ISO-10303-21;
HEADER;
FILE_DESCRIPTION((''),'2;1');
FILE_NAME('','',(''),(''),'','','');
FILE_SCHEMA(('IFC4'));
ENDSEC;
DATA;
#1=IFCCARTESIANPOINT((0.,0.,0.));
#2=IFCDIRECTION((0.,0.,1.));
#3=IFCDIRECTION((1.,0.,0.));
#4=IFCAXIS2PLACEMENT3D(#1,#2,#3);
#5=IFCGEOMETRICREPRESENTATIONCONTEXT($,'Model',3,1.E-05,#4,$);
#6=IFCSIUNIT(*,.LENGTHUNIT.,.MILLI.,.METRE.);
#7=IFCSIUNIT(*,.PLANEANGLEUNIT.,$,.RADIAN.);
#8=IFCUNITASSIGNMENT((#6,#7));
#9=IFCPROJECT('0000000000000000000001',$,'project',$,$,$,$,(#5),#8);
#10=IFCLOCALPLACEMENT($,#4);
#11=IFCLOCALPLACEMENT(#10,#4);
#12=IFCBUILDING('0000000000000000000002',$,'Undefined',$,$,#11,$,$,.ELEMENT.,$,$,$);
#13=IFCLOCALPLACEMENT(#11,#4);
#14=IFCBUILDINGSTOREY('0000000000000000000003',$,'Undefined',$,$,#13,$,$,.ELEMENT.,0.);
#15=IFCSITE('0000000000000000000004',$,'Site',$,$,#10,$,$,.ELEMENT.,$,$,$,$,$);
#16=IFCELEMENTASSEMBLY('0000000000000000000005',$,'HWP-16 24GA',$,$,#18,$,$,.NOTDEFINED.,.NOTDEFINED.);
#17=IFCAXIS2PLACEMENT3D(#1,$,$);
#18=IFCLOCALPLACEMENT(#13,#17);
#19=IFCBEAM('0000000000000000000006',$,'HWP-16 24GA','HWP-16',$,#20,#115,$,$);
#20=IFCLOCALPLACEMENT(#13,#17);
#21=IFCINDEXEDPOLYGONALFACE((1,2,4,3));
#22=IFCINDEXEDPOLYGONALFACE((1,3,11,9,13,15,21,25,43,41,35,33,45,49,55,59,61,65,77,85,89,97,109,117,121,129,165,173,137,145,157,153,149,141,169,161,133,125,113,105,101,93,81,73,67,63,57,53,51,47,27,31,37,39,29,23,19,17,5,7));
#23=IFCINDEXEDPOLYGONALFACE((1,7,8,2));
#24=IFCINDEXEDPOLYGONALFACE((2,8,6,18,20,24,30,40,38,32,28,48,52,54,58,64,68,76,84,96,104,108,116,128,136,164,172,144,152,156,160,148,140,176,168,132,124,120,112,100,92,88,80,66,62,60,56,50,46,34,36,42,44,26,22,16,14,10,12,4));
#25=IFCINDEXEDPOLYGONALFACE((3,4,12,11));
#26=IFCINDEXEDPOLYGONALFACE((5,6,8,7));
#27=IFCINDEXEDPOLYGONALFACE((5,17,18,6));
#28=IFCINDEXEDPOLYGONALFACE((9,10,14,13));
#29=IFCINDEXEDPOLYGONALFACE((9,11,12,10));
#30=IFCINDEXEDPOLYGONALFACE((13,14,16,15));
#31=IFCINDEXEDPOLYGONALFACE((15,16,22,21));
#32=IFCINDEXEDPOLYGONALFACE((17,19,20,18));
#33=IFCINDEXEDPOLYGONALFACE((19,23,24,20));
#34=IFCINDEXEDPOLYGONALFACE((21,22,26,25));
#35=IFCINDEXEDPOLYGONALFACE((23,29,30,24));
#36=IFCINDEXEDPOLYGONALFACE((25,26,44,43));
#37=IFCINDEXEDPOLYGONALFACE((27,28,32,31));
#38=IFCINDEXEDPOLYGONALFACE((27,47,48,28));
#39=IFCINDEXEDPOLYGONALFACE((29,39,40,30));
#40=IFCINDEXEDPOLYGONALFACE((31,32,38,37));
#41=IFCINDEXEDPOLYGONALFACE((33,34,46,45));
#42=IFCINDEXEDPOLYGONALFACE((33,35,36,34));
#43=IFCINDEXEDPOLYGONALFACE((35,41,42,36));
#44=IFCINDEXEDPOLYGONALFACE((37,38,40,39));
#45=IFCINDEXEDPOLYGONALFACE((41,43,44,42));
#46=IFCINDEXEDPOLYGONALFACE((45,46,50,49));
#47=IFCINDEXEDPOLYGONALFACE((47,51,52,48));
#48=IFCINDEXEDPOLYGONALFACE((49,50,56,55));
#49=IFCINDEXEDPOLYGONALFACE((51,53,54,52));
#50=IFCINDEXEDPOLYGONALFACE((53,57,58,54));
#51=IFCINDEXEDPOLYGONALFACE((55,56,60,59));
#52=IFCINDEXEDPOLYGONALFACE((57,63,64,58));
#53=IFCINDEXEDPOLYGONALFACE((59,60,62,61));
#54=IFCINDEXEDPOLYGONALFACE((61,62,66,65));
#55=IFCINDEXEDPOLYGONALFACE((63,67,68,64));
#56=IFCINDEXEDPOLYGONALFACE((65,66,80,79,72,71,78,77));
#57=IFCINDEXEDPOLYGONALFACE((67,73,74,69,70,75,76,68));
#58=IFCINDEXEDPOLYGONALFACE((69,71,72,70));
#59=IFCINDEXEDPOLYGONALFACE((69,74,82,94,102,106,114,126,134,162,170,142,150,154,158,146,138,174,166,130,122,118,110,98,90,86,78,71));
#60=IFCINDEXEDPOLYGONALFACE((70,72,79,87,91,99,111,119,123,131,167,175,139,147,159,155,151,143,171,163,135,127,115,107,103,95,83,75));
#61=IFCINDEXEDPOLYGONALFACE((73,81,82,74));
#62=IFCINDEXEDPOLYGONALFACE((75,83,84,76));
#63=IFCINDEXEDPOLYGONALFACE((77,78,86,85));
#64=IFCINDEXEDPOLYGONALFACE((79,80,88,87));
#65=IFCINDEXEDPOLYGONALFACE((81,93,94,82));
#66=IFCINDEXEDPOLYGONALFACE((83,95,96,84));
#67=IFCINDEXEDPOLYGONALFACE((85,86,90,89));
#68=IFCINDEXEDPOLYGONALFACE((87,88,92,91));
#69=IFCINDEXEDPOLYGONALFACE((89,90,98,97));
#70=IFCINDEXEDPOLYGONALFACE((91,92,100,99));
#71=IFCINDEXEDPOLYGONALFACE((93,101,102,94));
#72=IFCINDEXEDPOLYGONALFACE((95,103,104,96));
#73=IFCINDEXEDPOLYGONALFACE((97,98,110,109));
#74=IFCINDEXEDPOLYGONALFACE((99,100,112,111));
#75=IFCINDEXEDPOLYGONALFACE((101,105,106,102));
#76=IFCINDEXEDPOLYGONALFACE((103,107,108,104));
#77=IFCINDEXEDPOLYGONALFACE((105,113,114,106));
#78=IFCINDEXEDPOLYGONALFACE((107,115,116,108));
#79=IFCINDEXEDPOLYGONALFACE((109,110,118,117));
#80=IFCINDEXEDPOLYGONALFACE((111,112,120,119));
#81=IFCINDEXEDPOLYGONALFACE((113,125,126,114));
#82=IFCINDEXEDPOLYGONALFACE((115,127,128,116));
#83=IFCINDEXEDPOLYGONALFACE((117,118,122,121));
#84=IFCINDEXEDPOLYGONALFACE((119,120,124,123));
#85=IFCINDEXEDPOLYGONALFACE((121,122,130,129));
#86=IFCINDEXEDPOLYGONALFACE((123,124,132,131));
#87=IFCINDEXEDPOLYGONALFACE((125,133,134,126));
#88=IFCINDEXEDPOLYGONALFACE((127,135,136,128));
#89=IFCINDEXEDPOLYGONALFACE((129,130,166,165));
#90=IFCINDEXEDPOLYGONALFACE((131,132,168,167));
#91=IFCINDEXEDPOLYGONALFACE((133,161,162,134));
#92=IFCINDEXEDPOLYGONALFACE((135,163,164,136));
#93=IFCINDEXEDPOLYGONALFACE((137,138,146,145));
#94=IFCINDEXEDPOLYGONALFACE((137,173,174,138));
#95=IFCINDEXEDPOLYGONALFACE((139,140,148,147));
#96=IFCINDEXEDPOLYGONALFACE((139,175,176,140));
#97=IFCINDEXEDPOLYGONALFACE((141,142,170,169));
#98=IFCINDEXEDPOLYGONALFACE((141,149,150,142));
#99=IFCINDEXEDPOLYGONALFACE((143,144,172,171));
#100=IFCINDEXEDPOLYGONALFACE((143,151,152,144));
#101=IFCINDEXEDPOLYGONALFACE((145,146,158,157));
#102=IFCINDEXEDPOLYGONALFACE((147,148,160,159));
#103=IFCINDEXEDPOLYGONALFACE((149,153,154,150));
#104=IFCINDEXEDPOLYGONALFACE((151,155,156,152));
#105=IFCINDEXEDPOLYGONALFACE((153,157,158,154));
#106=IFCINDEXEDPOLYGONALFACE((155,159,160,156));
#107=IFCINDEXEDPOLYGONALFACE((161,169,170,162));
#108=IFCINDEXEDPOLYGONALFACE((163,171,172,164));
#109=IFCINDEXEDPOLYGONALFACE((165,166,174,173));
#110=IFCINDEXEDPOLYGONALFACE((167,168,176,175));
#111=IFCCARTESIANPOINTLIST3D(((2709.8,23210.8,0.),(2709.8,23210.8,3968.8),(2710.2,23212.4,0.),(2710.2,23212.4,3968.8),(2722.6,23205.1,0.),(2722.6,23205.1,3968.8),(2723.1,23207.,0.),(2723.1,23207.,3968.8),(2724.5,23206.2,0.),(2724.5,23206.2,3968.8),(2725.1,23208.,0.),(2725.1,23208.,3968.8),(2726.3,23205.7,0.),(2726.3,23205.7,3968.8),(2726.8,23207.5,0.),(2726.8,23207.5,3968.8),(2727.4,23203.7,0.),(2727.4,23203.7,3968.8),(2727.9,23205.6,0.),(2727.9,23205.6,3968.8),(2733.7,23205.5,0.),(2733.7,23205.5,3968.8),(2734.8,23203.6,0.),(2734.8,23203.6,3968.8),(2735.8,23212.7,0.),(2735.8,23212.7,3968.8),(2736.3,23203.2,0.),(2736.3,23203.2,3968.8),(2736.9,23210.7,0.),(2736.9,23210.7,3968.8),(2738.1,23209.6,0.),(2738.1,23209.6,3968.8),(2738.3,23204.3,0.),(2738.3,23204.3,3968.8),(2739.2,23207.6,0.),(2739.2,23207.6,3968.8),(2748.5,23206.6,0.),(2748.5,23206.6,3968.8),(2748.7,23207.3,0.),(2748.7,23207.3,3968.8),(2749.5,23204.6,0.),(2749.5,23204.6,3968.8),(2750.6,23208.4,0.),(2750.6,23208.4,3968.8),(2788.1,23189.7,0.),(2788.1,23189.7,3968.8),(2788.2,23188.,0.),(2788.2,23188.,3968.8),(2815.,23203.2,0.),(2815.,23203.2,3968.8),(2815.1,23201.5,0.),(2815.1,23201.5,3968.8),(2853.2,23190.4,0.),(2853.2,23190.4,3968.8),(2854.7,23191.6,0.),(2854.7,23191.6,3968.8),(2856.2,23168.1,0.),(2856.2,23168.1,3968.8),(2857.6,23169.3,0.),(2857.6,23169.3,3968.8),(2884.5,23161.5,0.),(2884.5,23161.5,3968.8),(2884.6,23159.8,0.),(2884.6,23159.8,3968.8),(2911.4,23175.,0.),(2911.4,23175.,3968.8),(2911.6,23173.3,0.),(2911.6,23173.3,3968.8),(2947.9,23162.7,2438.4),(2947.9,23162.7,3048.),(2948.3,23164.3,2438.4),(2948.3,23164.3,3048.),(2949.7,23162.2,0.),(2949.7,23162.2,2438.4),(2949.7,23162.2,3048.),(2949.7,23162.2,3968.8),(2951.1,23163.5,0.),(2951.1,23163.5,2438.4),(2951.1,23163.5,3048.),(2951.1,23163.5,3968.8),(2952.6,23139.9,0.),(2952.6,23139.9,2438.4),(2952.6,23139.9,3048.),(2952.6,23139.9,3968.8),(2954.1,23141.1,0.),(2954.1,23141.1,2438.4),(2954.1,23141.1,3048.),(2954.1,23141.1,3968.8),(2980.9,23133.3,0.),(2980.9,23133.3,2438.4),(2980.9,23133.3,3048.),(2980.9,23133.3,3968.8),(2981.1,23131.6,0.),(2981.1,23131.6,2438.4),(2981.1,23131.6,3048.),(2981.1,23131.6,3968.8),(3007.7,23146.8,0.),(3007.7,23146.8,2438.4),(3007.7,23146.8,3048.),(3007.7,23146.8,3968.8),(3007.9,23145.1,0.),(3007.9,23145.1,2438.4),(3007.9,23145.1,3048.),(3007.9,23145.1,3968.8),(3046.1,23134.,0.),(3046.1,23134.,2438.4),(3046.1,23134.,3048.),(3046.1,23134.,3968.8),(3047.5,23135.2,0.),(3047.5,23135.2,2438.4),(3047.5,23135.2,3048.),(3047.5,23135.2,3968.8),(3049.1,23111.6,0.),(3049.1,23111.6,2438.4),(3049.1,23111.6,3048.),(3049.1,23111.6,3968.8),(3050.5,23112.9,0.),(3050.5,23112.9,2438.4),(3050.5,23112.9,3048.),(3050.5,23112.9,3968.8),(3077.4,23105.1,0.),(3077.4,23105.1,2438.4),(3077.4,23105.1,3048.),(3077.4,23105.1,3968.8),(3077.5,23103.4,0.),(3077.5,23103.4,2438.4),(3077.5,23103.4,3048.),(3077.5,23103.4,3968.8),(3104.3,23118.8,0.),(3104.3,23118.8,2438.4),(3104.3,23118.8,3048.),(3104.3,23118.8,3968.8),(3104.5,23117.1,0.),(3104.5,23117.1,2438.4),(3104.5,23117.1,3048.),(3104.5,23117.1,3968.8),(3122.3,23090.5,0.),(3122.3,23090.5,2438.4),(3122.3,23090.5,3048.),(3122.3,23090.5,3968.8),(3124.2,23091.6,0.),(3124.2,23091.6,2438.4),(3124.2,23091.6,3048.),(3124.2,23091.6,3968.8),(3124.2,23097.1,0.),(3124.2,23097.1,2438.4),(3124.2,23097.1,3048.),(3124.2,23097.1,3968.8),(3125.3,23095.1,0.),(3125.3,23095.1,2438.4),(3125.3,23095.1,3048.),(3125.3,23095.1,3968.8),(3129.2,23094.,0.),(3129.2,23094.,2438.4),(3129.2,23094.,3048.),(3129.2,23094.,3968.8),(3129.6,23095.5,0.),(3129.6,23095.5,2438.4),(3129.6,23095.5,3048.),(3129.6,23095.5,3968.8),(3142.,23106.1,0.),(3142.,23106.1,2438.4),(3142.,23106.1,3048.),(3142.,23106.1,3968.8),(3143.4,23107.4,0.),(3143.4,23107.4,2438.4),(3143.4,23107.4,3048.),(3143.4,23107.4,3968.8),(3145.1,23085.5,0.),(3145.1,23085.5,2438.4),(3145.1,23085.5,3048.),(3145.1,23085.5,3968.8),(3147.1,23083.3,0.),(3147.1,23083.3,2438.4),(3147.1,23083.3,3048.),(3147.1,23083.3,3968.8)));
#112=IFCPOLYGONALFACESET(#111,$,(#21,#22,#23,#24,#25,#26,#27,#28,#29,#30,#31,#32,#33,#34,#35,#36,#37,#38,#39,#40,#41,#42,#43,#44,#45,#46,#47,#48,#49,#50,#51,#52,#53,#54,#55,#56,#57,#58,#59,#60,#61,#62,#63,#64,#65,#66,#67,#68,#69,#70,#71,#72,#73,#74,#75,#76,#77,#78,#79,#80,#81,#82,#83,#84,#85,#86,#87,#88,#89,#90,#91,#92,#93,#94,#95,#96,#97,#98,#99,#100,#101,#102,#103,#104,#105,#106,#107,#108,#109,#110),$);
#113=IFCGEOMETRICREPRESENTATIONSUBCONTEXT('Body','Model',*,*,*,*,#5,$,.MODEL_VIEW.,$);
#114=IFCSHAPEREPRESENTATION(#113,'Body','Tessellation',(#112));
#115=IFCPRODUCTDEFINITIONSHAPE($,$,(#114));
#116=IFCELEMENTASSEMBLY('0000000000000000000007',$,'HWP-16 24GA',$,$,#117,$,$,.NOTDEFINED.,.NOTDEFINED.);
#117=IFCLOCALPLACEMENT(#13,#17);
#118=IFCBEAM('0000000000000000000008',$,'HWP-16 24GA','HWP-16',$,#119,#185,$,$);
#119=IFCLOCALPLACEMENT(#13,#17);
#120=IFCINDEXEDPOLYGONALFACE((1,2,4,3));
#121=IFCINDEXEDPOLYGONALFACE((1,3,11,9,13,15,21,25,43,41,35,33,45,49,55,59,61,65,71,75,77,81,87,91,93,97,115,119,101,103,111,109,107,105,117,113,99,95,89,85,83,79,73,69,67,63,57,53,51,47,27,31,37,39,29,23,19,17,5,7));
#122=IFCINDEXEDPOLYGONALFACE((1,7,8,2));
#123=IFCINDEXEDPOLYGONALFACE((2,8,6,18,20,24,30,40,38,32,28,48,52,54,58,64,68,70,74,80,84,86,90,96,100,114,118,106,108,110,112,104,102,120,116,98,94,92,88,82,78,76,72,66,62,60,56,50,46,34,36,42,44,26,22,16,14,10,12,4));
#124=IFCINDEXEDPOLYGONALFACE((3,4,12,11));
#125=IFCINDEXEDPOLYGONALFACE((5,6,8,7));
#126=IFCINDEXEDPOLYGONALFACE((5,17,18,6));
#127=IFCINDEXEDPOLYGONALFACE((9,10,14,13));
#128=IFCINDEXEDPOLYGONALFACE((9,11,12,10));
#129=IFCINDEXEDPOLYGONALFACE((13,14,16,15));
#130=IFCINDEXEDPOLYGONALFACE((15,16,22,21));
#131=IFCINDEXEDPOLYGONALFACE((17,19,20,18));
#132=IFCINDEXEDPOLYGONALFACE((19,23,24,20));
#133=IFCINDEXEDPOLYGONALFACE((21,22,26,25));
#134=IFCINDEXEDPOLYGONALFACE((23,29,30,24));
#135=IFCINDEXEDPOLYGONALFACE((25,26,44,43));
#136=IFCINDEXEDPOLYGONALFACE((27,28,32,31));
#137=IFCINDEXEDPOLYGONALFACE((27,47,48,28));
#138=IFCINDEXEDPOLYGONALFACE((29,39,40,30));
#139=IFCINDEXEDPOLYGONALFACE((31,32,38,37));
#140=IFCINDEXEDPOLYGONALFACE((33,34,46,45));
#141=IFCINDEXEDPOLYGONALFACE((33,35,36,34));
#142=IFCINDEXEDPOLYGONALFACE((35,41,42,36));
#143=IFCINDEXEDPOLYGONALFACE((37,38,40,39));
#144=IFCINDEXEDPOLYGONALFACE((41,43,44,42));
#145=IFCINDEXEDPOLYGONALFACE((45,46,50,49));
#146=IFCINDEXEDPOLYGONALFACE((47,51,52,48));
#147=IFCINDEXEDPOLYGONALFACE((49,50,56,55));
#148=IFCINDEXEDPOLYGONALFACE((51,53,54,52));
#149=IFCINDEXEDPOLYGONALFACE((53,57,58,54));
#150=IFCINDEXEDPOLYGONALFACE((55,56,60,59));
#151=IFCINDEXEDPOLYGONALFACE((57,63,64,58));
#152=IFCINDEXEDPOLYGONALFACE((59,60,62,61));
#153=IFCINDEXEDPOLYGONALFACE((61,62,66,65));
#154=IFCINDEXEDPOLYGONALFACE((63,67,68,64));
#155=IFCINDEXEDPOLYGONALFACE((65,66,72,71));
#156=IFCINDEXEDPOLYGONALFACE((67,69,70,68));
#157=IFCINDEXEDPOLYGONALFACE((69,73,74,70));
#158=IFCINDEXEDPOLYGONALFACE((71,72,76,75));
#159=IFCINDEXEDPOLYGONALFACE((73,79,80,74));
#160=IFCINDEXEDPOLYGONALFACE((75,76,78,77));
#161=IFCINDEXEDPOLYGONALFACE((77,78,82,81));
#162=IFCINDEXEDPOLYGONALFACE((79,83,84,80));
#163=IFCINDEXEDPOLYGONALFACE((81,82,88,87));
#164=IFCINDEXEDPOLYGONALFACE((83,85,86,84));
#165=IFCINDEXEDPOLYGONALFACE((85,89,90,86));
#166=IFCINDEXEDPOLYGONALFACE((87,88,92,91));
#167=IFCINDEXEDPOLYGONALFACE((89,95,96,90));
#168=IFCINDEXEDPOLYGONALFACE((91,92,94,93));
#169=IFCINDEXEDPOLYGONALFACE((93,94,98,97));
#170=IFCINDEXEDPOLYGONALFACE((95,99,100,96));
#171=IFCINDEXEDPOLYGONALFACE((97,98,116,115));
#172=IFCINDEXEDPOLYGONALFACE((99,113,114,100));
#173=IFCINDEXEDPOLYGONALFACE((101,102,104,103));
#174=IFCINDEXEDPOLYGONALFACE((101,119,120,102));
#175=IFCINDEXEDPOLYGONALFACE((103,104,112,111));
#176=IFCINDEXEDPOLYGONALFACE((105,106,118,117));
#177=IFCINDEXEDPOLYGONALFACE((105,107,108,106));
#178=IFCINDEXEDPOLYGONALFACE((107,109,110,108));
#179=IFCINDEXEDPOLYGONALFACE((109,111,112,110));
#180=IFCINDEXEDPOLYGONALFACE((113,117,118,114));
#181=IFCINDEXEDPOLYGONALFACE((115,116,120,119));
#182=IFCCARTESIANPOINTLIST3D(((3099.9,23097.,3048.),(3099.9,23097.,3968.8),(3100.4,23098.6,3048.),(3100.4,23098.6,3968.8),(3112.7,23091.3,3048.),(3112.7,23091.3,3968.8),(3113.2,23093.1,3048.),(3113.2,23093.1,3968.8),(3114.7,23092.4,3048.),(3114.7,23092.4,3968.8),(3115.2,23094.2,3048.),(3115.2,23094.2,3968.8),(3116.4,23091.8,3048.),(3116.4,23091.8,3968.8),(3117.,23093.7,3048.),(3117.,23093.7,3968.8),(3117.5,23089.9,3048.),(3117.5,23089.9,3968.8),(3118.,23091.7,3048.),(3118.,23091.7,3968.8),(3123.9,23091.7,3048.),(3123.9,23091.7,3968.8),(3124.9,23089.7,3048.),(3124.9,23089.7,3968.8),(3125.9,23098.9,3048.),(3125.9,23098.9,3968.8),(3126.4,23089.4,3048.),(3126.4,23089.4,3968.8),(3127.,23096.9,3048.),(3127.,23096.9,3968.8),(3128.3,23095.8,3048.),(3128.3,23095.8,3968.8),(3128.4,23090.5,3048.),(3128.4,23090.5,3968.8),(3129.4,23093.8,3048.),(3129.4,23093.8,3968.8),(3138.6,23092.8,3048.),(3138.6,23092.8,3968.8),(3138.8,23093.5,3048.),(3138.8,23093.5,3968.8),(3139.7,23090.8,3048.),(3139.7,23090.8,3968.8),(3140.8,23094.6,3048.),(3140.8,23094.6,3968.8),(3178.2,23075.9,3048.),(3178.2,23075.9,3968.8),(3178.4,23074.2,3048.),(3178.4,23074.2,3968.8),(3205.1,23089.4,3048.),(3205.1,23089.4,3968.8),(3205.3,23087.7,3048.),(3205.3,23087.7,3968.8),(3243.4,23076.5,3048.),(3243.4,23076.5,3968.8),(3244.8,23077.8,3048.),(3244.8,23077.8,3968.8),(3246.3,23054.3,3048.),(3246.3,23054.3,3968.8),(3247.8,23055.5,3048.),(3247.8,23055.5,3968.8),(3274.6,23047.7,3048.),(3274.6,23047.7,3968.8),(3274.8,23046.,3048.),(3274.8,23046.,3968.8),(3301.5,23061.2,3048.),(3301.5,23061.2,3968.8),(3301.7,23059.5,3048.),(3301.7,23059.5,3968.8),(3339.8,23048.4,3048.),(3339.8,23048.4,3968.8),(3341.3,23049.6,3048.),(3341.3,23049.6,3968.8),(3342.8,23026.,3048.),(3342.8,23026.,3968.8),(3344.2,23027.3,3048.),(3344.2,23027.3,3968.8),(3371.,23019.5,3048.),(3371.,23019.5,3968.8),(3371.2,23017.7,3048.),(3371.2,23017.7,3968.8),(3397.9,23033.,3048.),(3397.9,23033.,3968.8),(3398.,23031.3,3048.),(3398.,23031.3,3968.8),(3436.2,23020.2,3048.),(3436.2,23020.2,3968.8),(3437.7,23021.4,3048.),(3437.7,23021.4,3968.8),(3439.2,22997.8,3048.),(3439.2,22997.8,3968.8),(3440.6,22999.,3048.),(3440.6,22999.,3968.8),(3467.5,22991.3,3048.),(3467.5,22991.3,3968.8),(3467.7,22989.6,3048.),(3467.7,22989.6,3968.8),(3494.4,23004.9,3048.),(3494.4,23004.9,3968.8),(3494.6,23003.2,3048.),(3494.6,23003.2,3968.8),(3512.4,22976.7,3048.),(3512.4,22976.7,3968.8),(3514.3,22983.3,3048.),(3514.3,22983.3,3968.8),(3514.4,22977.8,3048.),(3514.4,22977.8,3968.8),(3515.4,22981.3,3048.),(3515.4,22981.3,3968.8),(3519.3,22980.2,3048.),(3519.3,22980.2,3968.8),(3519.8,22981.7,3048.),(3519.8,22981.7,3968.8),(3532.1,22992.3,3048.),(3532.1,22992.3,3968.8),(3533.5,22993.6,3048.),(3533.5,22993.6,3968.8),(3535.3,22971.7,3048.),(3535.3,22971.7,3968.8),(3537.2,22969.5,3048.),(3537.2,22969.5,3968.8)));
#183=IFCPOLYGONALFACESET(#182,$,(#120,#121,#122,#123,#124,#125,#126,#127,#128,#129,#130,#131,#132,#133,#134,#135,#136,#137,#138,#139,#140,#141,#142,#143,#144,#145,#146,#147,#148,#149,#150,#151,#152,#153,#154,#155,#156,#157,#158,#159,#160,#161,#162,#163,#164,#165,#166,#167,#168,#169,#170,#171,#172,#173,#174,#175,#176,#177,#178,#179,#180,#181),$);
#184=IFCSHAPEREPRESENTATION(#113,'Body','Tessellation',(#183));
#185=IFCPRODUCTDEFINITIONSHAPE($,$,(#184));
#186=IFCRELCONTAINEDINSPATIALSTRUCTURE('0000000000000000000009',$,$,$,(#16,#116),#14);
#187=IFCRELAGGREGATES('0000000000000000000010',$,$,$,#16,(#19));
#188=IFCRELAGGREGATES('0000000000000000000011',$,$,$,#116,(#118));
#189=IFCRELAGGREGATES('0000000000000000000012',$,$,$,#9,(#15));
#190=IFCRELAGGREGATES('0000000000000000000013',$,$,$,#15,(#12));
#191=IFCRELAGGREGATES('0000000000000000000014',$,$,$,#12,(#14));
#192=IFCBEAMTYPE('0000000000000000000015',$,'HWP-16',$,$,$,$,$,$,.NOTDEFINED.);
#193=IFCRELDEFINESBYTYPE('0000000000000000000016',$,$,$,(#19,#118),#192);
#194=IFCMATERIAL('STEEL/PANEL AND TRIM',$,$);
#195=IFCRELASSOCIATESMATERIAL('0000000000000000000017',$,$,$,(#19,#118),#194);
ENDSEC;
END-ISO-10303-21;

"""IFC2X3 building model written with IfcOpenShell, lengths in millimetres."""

from ifc_helpers import new_model, si_unit, frame, origin_with_axes, place, context, subcontext, project, spatial, polyline, outline, extrude, boolean, halfspace, material, type_object, element, aggregate, save


model = new_model("IFC2X3")

# Units and contexts
model_context = context("Model", 3, precision=1e-05, world=origin_with_axes())
body_context = subcontext(model_context, "Body", "Model", "MODEL_VIEW")
ifc_project = project(units=[si_unit("LENGTHUNIT", "METRE", prefix="MILLI"), si_unit("PLANEANGLEUNIT", "RADIAN")], contexts=[model_context])

# Site, building, storey
site_placement = place(None, origin_with_axes())
site = spatial("IfcSite", under=ifc_project, at=site_placement, Name="Site", CompositionType="ELEMENT")
building_placement = place(site_placement, origin_with_axes())
building = spatial("IfcBuilding", under=site, at=building_placement, Name="Undefined", CompositionType="ELEMENT")
storey_placement = place(building_placement, origin_with_axes())
storey = spatial("IfcBuildingStorey", under=building, at=storey_placement, Name="Undefined", CompositionType="ELEMENT", Elevation=0.0)

# Element assemblies, beams
ifc_material_1 = material(Name="STEEL/PANEL AND TRIM")
beam_type_1 = type_object("IfcBeamType", Name="HWP-16", PredefinedType="NOTDEFINED")
assembly_1_placement = place(storey_placement, origin_with_axes())
assembly_1 = element("IfcElementAssembly", 1, at=assembly_1_placement, inside=storey, Name="HWP-16 24GA", AssemblyPlace="NOTDEFINED", PredefinedType="NOTDEFINED")
beam_1_placement = place(assembly_1_placement, frame((3143.4, 23107.4, 3968.8), z_axis=(-0.280057, -0.959983, 0.0), x_axis=(0.0, 0.0, -1.0)))
beam_1 = element("IfcBeam", 2, at=beam_1_placement, type_object=beam_type_1, material=ifc_material_1, Name="HWP-16 24GA", Description="HWP-16", context=body_context, shape_type="CSG", body=[
    boolean("DIFFERENCE", boolean("DIFFERENCE", extrude(outline(polyline([(40.7, 0.0), (0.0, 0.0), (-10.3, 22.1), (15.5, 22.1), (15.5, 15.2), (9.9, 15.2), (9.9, 16.8), (13.9, 16.8), (13.9, 20.5), (-7.8, 20.5), (1.0, 1.6), (40.1, 1.6), (62.1, 22.2), (91.7, 22.3), (100.8, 1.7), (140.6, 1.7), (162.6, 22.2), (192.2, 22.2), (201.3, 1.6), (241.0, 1.6), (263.1, 22.1), (292.7, 22.1), (301.8, 1.6), (341.5, 1.6), (363.5, 22.0), (417.6, 22.0), (417.6, 15.3), (406.9, 15.3), (406.9, 14.6), (419.2, 14.6), (419.2, 22.1), (426.4, 22.1), (426.4, 24.0), (431.3, 24.0), (431.3, 22.1), (445.2, 22.1), (445.2, 20.5), (429.7, 20.5), (429.7, 22.5), (427.9, 22.5), (427.9, 20.5), (420.7, 20.5), (420.7, 13.0), (405.3, 13.0), (405.3, 16.9), (416.0, 16.9), (416.0, 20.4), (364.1, 20.4), (342.1, 0.0), (300.7, 0.0), (291.6, 20.5), (263.7, 20.5), (241.6, 0.0), (200.3, 0.0), (191.2, 20.6), (163.2, 20.6), (141.3, 0.1), (99.8, 0.1), (90.7, 20.7), (62.7, 20.6), (40.7, 0.0)])), frame((10000.0, 0.0, 0.0), z_axis=(-1.0, 0.0, 0.0), x_axis=(0.0, -1.0, 0.0)), (0.0, 0.0, 1.0), 10000.0), extrude(outline(polyline([(0.0, 0.0), (5029.2, 0.0), (5029.2, 609.6), (0.0, 609.6), (0.0, 0.0)])), frame((920.8, 4826.0, -10.0), z_axis=(0.0, 0.0, 1.0), x_axis=(0.0, -1.0, 0.0)), (0.0, 0.0, 1.0), 44.0)), halfspace(frame((3968.8, -500.0, -500.0), z_axis=(1.0, 0.0, 0.0), x_axis=(0.0, 0.0, 1.0)), False)),
])
aggregate(assembly_1, [beam_1])
assembly_2_placement = place(storey_placement, origin_with_axes())
assembly_2 = element("IfcElementAssembly", 3, at=assembly_2_placement, inside=storey, Name="HWP-16 24GA", AssemblyPlace="NOTDEFINED", PredefinedType="NOTDEFINED")
beam_2_placement = place(assembly_2_placement, frame((3533.5, 22993.6, 3968.8), z_axis=(-0.280057, -0.959983, 0.0), x_axis=(0.0, 0.0, -1.0)))
beam_2 = element("IfcBeam", 4, at=beam_2_placement, type_object=beam_type_1, material=ifc_material_1, Name="HWP-16 24GA", Description="HWP-16", context=body_context, shape_type="CSG", body=[
    boolean("DIFFERENCE", extrude(outline(polyline([(40.7, 0.0), (0.0, 0.0), (-10.3, 22.1), (15.5, 22.1), (15.5, 15.2), (9.9, 15.2), (9.9, 16.8), (13.9, 16.8), (13.9, 20.5), (-7.8, 20.5), (1.0, 1.6), (40.1, 1.6), (62.1, 22.2), (91.7, 22.3), (100.8, 1.7), (140.6, 1.7), (162.6, 22.2), (192.2, 22.2), (201.3, 1.6), (241.0, 1.6), (263.1, 22.1), (292.7, 22.1), (301.8, 1.6), (341.5, 1.6), (363.5, 22.0), (417.6, 22.0), (417.6, 15.3), (406.9, 15.3), (406.9, 14.6), (419.2, 14.6), (419.2, 22.1), (426.4, 22.1), (426.4, 24.0), (431.3, 24.0), (431.3, 22.1), (445.2, 22.1), (445.2, 20.5), (429.7, 20.5), (429.7, 22.5), (427.9, 22.5), (427.9, 20.5), (420.7, 20.5), (420.7, 13.0), (405.3, 13.0), (405.3, 16.9), (416.0, 16.9), (416.0, 20.4), (364.1, 20.4), (342.1, 0.0), (300.7, 0.0), (291.6, 20.5), (263.7, 20.5), (241.6, 0.0), (200.3, 0.0), (191.2, 20.6), (163.2, 20.6), (141.3, 0.1), (99.8, 0.1), (90.7, 20.7), (62.7, 20.6), (40.7, 0.0)])), frame((1225.5, 0.0, 0.0), z_axis=(-1.0, 0.0, 0.0), x_axis=(0.0, -1.0, 0.0)), (0.0, 0.0, 1.0), 1225.5), extrude(outline(polyline([(0.0, 0.0), (5029.2, 0.0), (5029.2, 609.6), (0.0, 609.6), (0.0, 0.0)])), frame((920.8, 4419.6, -10.0), z_axis=(0.0, 0.0, 1.0), x_axis=(0.0, -1.0, 0.0)), (0.0, 0.0, 1.0), 44.0)),
])
aggregate(assembly_2, [beam_2])

save(model, "model.ifc")
